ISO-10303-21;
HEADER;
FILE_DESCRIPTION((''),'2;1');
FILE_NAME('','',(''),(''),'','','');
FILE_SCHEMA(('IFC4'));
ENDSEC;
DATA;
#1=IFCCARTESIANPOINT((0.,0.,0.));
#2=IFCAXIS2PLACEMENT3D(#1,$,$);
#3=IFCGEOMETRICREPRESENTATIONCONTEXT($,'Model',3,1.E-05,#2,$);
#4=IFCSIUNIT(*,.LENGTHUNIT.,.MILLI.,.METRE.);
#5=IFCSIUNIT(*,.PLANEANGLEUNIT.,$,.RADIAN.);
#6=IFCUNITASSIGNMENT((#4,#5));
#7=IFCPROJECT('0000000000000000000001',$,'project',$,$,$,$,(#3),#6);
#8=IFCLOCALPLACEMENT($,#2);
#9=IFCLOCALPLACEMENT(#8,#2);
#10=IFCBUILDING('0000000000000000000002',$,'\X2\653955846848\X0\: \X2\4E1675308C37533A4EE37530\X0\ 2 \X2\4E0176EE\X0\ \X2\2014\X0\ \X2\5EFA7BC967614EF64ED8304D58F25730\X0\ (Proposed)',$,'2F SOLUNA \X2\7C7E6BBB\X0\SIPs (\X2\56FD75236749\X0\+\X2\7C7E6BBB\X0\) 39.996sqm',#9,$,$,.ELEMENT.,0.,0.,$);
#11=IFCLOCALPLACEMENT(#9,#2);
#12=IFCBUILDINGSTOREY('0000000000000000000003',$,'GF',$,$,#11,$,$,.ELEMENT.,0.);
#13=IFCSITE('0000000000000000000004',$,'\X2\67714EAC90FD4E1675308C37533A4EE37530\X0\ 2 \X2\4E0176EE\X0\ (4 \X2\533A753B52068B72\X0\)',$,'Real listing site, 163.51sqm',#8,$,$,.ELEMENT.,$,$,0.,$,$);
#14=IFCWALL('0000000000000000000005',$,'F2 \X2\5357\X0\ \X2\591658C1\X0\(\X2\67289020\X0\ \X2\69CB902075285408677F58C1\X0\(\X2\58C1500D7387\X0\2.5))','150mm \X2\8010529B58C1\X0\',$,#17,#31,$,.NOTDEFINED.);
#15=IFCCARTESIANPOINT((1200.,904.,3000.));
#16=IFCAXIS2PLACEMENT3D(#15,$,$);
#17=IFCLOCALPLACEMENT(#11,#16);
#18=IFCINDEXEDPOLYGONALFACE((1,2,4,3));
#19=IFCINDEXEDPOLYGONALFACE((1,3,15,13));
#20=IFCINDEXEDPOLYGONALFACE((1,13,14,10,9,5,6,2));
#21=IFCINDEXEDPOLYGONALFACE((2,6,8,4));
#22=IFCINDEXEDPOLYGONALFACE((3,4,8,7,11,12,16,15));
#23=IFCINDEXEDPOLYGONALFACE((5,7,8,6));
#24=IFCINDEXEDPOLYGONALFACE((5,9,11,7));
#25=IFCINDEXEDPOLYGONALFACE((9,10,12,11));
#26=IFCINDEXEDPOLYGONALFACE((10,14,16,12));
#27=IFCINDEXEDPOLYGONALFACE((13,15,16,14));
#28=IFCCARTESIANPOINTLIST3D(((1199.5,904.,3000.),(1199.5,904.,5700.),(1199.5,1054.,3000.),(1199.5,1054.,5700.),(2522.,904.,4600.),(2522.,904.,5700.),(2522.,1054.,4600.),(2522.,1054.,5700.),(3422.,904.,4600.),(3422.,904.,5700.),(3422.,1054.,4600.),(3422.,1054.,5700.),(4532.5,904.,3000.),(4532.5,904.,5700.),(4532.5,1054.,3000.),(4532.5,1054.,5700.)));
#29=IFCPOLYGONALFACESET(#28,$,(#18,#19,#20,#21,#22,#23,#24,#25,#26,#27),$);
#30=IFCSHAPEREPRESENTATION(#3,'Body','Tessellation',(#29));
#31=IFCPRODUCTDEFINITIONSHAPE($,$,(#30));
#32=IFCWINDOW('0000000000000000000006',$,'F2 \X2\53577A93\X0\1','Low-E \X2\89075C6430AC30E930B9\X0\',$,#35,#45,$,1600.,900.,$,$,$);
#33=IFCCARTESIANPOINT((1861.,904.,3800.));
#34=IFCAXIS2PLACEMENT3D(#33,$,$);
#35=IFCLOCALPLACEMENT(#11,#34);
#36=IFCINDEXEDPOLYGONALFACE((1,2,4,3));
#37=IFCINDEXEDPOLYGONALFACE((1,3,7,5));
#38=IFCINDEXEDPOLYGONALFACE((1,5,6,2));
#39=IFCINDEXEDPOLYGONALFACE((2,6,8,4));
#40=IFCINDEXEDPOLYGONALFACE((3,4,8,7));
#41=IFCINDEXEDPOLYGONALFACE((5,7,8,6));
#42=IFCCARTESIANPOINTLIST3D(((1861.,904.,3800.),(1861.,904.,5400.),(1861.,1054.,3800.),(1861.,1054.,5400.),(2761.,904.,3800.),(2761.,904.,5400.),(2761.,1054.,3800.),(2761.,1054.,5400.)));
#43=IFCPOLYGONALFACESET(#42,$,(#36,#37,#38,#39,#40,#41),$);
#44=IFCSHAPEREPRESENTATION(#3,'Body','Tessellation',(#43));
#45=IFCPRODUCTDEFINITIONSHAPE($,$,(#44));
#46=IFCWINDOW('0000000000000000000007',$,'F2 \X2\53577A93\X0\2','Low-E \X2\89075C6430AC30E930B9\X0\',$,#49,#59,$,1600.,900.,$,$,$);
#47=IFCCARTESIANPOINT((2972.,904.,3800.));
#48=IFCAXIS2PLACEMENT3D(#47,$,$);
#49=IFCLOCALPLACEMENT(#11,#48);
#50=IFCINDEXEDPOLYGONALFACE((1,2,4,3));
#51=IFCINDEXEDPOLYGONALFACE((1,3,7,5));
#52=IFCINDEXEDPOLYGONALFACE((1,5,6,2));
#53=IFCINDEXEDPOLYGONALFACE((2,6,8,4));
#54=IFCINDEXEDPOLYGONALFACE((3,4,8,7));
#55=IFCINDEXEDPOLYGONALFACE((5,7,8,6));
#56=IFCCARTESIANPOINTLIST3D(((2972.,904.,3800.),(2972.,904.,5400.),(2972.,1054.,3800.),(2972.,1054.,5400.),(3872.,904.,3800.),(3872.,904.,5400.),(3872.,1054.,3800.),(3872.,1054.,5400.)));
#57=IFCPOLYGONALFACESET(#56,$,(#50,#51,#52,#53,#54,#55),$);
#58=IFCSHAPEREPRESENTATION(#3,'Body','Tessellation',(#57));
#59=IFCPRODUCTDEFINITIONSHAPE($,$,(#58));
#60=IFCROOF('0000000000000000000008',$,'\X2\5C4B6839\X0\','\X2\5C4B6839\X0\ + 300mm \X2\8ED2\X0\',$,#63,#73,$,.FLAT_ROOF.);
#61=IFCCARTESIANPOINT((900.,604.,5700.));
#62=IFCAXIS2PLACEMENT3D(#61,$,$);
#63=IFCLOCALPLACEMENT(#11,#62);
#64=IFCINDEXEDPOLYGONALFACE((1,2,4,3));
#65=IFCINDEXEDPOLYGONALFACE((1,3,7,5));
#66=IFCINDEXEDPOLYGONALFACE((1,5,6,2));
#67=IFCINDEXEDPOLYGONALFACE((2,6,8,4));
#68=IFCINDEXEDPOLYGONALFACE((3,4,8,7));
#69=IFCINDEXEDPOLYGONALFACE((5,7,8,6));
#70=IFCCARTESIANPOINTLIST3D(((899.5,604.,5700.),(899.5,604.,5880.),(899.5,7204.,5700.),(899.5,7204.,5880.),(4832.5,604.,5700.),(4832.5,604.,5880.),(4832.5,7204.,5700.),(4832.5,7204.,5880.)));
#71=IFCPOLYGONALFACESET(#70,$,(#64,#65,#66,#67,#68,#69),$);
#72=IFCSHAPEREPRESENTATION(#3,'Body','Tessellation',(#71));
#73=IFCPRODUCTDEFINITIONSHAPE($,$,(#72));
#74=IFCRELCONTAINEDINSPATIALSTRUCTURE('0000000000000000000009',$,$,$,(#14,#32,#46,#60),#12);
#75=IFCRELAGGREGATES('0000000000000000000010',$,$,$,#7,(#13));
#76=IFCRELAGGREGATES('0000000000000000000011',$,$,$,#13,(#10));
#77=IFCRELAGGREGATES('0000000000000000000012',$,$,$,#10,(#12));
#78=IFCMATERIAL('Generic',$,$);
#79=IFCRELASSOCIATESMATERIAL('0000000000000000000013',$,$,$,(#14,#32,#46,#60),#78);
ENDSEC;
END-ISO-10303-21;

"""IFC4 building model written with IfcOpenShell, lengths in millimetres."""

from ifc_helpers import new_model, si_unit, frame, frame_2d, origin, place, context, project, spatial, rectangle, extrude, material, element, fill, save


model = new_model("IFC4")

# Units and contexts
model_context = context("Model", 3, precision=1e-05, world=origin())
ifc_project = project(units=[si_unit("LENGTHUNIT", "METRE", prefix="MILLI"), si_unit("PLANEANGLEUNIT", "RADIAN")], contexts=[model_context])

# Site, building, storey
site_placement = place(None, origin())
site = spatial("IfcSite", under=ifc_project, at=site_placement, Name="東京都世田谷区代田 2 丁目 (4 区画分譲)", ObjectType="Real listing site, 163.51sqm", CompositionType="ELEMENT", RefElevation=0.0)
building_placement = place(site_placement, origin())
building = spatial("IfcBuilding", under=site, at=building_placement, Name="改善案: 世田谷区代田 2 丁目 — 建築条件付き売地 (Proposed)", ObjectType="2F SOLUNA 籾殻SIPs (国産杉+籾殻) 39.996sqm", CompositionType="ELEMENT", ElevationOfRefHeight=0.0, ElevationOfTerrain=0.0)
storey_placement = place(building_placement, origin())
storey = spatial("IfcBuildingStorey", under=building, at=storey_placement, Name="GF", CompositionType="ELEMENT", Elevation=0.0)

# Shared definitions
ifc_material_1 = material(Name="Generic")

# Wall, openings, windows
wall_1_placement = place(storey_placement, frame((1200.0, 904.0, 3000.0)))
wall_1 = element("IfcWall", 1, at=wall_1_placement, inside=storey, material=ifc_material_1, Name="F2 南 外壁(木造 構造用合板壁(壁倍率2.5))", Description="150mm 耐力壁", PredefinedType="NOTDEFINED", context=model_context, shape_type="SweptSolid", body=[
    extrude(rectangle(XDim=3333.0, YDim=150.0, at=frame_2d((1666.0, 75.0))), frame((1200.0, 904.0, 3000.0)), (0.0, 0.0, 1.0), 2700.0),
])
opening_1_placement = place(storey_placement, frame((1861.0, 904.0, 3800.0)))
opening_1 = element("IfcOpeningElement", 2, at=opening_1_placement, cuts=wall_1, PredefinedType="NOTDEFINED", context=model_context, shape_type="SweptSolid", body=[
    extrude(rectangle(XDim=900.0, YDim=150.0, at=frame_2d((450.0, 75.0))), frame((1861.0, 904.0, 3800.0)), (0.0, 0.0, 1.0), 1600.0),
])
opening_2_placement = place(storey_placement, frame((2972.0, 904.0, 3800.0)))
opening_2 = element("IfcOpeningElement", 3, at=opening_2_placement, cuts=wall_1, PredefinedType="NOTDEFINED", context=model_context, shape_type="SweptSolid", body=[
    extrude(rectangle(XDim=900.0, YDim=150.0, at=frame_2d((450.0, 75.0))), frame((2972.0, 904.0, 3800.0)), (0.0, 0.0, 1.0), 1600.0),
])
window_1_placement = place(storey_placement, frame((1861.0, 904.0, 3800.0)))
window_1 = element("IfcWindow", 4, at=window_1_placement, inside=storey, material=ifc_material_1, Name="F2 南窓1", Description="Low-E 複層ガラス", OverallHeight=1600.0, OverallWidth=900.0, context=model_context, shape_type="SweptSolid", body=[
    extrude(rectangle(XDim=900.0, YDim=150.0, at=frame_2d((450.0, 75.0))), frame((1861.0, 904.0, 3800.0)), (0.0, 0.0, 1.0), 1600.0),
])
fill(opening_1, window_1)
window_2_placement = place(storey_placement, frame((2972.0, 904.0, 3800.0)))
window_2 = element("IfcWindow", 5, at=window_2_placement, inside=storey, material=ifc_material_1, Name="F2 南窓2", Description="Low-E 複層ガラス", OverallHeight=1600.0, OverallWidth=900.0, context=model_context, shape_type="SweptSolid", body=[
    extrude(rectangle(XDim=900.0, YDim=150.0, at=frame_2d((450.0, 75.0))), frame((2972.0, 904.0, 3800.0)), (0.0, 0.0, 1.0), 1600.0),
])
fill(opening_2, window_2)

# Roof
roof_placement = place(storey_placement, frame((900.0, 604.0, 5700.0)))
element("IfcRoof", 6, at=roof_placement, inside=storey, material=ifc_material_1, Name="屋根", Description="屋根 + 300mm 軒", PredefinedType="FLAT_ROOF", context=model_context, shape_type="SweptSolid", body=[
    extrude(rectangle(XDim=3933.0, YDim=6600.0, at=frame_2d((1966.0, 3300.0))), frame((900.0, 604.0, 5700.0)), (0.0, 0.0, 1.0), 180.0),
])

save(model, "model.ifc")
